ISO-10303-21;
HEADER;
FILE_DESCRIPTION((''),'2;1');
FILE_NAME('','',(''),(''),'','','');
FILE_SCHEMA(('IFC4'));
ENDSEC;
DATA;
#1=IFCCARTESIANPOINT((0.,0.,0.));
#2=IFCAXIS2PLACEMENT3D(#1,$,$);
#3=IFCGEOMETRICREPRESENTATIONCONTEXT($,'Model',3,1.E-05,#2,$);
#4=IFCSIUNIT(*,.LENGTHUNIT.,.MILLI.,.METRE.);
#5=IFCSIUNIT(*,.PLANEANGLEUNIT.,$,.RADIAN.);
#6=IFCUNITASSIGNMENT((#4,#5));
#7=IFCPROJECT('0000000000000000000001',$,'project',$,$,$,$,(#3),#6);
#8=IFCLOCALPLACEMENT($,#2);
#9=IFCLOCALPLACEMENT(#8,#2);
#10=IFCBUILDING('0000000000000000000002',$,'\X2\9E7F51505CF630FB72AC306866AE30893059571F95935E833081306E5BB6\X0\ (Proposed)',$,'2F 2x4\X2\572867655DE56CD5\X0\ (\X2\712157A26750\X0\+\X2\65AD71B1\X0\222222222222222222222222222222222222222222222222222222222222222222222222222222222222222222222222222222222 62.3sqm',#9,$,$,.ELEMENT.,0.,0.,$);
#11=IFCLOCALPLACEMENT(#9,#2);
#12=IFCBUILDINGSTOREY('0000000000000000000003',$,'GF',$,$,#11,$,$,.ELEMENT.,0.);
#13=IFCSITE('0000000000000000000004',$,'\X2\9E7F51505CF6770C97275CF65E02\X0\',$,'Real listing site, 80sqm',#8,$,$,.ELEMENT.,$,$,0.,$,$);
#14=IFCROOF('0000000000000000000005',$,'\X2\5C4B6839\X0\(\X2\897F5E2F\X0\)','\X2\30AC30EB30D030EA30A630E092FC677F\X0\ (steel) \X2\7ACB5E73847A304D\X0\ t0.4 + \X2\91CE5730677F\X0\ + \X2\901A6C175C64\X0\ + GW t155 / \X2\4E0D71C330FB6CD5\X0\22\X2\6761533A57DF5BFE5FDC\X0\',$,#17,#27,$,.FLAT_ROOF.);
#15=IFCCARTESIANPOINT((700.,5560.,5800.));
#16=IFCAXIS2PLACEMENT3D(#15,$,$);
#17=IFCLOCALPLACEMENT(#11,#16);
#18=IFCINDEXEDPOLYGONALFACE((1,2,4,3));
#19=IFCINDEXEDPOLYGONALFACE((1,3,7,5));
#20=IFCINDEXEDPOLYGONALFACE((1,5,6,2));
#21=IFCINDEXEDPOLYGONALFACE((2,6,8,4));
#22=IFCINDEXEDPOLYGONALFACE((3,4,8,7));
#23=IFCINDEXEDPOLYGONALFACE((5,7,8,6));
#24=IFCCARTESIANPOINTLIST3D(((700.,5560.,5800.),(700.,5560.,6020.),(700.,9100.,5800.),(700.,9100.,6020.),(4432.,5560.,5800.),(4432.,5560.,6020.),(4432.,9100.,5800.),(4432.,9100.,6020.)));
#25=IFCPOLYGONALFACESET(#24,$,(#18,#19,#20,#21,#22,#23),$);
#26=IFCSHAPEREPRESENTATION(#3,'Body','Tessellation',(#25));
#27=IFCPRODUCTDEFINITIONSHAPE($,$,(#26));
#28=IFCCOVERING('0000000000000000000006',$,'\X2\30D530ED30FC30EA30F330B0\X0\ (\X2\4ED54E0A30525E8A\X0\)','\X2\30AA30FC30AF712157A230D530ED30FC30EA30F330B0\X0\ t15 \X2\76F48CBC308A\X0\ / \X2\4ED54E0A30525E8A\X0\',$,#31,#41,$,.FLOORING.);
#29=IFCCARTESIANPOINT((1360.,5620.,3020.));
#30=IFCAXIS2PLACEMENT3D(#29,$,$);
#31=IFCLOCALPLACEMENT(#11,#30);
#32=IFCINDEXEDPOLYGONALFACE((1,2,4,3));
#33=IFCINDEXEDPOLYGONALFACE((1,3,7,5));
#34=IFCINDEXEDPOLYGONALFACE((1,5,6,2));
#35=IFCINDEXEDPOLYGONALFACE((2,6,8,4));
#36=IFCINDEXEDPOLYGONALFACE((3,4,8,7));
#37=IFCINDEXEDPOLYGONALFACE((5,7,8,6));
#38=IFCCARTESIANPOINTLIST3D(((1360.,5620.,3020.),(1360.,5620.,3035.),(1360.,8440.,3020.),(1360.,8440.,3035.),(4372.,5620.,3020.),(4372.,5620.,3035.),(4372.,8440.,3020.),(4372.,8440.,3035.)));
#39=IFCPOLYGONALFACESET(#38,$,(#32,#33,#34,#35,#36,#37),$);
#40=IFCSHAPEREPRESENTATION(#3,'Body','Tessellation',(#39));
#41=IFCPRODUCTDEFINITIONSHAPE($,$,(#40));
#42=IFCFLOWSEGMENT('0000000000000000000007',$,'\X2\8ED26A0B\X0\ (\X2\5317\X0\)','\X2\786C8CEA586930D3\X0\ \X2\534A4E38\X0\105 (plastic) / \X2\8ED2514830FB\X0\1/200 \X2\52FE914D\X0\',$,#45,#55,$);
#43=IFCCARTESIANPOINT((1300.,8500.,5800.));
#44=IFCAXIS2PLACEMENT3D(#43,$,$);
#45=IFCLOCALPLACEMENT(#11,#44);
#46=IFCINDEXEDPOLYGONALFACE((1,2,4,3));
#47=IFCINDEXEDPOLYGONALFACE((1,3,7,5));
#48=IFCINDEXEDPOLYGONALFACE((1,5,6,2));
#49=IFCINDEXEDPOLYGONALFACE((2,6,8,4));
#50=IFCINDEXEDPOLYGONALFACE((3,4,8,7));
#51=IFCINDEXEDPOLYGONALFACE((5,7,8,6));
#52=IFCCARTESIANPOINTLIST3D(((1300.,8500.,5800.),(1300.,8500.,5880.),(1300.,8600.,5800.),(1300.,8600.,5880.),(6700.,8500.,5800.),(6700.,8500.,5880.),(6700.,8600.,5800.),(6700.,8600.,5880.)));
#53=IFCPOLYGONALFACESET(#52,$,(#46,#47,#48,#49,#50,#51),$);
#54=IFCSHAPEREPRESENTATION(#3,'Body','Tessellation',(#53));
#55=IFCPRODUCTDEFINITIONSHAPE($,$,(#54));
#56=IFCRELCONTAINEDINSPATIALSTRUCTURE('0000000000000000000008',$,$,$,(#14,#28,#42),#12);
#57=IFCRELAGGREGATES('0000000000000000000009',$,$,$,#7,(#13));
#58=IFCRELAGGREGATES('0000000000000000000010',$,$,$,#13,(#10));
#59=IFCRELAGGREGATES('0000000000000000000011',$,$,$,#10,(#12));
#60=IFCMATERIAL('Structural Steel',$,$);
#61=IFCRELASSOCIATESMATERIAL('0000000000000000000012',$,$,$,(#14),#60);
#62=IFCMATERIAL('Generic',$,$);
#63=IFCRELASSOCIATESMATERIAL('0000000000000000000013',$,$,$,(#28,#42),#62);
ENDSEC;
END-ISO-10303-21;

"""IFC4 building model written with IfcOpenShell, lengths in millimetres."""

from ifc_helpers import new_model, si_unit, frame, frame_2d, origin, place, context, project, spatial, rectangle, extrude, material, element, save


model = new_model("IFC4")

# Units and contexts
model_context = context("Model", 3, precision=1e-05, world=origin())
ifc_project = project(units=[si_unit("LENGTHUNIT", "METRE", prefix="MILLI"), si_unit("PLANEANGLEUNIT", "RADIAN")], contexts=[model_context])

# Site, building, storey
site_placement = place(None, origin())
site = spatial("IfcSite", under=ifc_project, at=site_placement, Name="鹿児島県霧島市", ObjectType="Real listing site, 80sqm", CompositionType="ELEMENT", RefElevation=0.0)
building_placement = place(site_placement, origin())
building = spatial("IfcBuilding", under=site, at=building_placement, Name="鹿児島・犬と暮らす土間広めの家 (Proposed)", ObjectType="2F 2x4在来工法 (無垢材+断熱222222222222222222222222222222222222222222222222222222222222222222222222222222222222222222222222222222222 62.3sqm", CompositionType="ELEMENT", ElevationOfRefHeight=0.0, ElevationOfTerrain=0.0)
storey_placement = place(building_placement, origin())
storey = spatial("IfcBuildingStorey", under=building, at=storey_placement, Name="GF", CompositionType="ELEMENT", Elevation=0.0)

# Roof
ifc_material_1 = material(Name="Structural Steel")
for number, where, name in (
    (1, (700.0, 5560.0, 5800.0), "屋根(西帯)"),
):
    element("IfcRoof", number, at=place(storey_placement, frame(where)), inside=storey, material=ifc_material_1, Name=name, Description="ガルバリウム鋼板 (steel) 立平葺き t0.4 + 野地板 + 通気層 + GW t155 / 不燃・法22条区域対応", PredefinedType="FLAT_ROOF", context=model_context, shape_type="SweptSolid", body=[
        extrude(rectangle(XDim=3732.0, YDim=3540.0, at=frame_2d((1866.0, 1770.0))), frame((700.0, 5560.0, 5800.0)), (0.0, 0.0, 1.0), 220.0),
    ])

# Covering
ifc_material_2 = material(Name="Generic")
covering_placement = place(storey_placement, frame((1360.0, 5620.0, 3020.0)))
element("IfcCovering", 2, at=covering_placement, inside=storey, material=ifc_material_2, Name="フローリング (仕上げ床)", Description="オーク無垢フローリング t15 直貼り / 仕上げ床", PredefinedType="FLOORING", context=model_context, shape_type="SweptSolid", body=[
    extrude(rectangle(XDim=3012.0, YDim=2820.0, at=frame_2d((1506.0, 1410.0))), frame((1360.0, 5620.0, 3020.0)), (0.0, 0.0, 1.0), 15.0),
])

# Flow segment
flow_segment_placement = place(storey_placement, frame((1300.0, 8500.0, 5800.0)))
element("IfcFlowSegment", 3, at=flow_segment_placement, inside=storey, material=ifc_material_2, Name="軒樋 (北)", Description="硬質塩ビ 半丸105 (plastic) / 軒先・1/200 勾配", context=model_context, shape_type="SweptSolid", body=[
    extrude(rectangle(XDim=5400.0, YDim=100.0, at=frame_2d((2700.0, 50.0))), frame((1300.0, 8500.0, 5800.0)), (0.0, 0.0, 1.0), 80.0),
])

save(model, "model.ifc")
